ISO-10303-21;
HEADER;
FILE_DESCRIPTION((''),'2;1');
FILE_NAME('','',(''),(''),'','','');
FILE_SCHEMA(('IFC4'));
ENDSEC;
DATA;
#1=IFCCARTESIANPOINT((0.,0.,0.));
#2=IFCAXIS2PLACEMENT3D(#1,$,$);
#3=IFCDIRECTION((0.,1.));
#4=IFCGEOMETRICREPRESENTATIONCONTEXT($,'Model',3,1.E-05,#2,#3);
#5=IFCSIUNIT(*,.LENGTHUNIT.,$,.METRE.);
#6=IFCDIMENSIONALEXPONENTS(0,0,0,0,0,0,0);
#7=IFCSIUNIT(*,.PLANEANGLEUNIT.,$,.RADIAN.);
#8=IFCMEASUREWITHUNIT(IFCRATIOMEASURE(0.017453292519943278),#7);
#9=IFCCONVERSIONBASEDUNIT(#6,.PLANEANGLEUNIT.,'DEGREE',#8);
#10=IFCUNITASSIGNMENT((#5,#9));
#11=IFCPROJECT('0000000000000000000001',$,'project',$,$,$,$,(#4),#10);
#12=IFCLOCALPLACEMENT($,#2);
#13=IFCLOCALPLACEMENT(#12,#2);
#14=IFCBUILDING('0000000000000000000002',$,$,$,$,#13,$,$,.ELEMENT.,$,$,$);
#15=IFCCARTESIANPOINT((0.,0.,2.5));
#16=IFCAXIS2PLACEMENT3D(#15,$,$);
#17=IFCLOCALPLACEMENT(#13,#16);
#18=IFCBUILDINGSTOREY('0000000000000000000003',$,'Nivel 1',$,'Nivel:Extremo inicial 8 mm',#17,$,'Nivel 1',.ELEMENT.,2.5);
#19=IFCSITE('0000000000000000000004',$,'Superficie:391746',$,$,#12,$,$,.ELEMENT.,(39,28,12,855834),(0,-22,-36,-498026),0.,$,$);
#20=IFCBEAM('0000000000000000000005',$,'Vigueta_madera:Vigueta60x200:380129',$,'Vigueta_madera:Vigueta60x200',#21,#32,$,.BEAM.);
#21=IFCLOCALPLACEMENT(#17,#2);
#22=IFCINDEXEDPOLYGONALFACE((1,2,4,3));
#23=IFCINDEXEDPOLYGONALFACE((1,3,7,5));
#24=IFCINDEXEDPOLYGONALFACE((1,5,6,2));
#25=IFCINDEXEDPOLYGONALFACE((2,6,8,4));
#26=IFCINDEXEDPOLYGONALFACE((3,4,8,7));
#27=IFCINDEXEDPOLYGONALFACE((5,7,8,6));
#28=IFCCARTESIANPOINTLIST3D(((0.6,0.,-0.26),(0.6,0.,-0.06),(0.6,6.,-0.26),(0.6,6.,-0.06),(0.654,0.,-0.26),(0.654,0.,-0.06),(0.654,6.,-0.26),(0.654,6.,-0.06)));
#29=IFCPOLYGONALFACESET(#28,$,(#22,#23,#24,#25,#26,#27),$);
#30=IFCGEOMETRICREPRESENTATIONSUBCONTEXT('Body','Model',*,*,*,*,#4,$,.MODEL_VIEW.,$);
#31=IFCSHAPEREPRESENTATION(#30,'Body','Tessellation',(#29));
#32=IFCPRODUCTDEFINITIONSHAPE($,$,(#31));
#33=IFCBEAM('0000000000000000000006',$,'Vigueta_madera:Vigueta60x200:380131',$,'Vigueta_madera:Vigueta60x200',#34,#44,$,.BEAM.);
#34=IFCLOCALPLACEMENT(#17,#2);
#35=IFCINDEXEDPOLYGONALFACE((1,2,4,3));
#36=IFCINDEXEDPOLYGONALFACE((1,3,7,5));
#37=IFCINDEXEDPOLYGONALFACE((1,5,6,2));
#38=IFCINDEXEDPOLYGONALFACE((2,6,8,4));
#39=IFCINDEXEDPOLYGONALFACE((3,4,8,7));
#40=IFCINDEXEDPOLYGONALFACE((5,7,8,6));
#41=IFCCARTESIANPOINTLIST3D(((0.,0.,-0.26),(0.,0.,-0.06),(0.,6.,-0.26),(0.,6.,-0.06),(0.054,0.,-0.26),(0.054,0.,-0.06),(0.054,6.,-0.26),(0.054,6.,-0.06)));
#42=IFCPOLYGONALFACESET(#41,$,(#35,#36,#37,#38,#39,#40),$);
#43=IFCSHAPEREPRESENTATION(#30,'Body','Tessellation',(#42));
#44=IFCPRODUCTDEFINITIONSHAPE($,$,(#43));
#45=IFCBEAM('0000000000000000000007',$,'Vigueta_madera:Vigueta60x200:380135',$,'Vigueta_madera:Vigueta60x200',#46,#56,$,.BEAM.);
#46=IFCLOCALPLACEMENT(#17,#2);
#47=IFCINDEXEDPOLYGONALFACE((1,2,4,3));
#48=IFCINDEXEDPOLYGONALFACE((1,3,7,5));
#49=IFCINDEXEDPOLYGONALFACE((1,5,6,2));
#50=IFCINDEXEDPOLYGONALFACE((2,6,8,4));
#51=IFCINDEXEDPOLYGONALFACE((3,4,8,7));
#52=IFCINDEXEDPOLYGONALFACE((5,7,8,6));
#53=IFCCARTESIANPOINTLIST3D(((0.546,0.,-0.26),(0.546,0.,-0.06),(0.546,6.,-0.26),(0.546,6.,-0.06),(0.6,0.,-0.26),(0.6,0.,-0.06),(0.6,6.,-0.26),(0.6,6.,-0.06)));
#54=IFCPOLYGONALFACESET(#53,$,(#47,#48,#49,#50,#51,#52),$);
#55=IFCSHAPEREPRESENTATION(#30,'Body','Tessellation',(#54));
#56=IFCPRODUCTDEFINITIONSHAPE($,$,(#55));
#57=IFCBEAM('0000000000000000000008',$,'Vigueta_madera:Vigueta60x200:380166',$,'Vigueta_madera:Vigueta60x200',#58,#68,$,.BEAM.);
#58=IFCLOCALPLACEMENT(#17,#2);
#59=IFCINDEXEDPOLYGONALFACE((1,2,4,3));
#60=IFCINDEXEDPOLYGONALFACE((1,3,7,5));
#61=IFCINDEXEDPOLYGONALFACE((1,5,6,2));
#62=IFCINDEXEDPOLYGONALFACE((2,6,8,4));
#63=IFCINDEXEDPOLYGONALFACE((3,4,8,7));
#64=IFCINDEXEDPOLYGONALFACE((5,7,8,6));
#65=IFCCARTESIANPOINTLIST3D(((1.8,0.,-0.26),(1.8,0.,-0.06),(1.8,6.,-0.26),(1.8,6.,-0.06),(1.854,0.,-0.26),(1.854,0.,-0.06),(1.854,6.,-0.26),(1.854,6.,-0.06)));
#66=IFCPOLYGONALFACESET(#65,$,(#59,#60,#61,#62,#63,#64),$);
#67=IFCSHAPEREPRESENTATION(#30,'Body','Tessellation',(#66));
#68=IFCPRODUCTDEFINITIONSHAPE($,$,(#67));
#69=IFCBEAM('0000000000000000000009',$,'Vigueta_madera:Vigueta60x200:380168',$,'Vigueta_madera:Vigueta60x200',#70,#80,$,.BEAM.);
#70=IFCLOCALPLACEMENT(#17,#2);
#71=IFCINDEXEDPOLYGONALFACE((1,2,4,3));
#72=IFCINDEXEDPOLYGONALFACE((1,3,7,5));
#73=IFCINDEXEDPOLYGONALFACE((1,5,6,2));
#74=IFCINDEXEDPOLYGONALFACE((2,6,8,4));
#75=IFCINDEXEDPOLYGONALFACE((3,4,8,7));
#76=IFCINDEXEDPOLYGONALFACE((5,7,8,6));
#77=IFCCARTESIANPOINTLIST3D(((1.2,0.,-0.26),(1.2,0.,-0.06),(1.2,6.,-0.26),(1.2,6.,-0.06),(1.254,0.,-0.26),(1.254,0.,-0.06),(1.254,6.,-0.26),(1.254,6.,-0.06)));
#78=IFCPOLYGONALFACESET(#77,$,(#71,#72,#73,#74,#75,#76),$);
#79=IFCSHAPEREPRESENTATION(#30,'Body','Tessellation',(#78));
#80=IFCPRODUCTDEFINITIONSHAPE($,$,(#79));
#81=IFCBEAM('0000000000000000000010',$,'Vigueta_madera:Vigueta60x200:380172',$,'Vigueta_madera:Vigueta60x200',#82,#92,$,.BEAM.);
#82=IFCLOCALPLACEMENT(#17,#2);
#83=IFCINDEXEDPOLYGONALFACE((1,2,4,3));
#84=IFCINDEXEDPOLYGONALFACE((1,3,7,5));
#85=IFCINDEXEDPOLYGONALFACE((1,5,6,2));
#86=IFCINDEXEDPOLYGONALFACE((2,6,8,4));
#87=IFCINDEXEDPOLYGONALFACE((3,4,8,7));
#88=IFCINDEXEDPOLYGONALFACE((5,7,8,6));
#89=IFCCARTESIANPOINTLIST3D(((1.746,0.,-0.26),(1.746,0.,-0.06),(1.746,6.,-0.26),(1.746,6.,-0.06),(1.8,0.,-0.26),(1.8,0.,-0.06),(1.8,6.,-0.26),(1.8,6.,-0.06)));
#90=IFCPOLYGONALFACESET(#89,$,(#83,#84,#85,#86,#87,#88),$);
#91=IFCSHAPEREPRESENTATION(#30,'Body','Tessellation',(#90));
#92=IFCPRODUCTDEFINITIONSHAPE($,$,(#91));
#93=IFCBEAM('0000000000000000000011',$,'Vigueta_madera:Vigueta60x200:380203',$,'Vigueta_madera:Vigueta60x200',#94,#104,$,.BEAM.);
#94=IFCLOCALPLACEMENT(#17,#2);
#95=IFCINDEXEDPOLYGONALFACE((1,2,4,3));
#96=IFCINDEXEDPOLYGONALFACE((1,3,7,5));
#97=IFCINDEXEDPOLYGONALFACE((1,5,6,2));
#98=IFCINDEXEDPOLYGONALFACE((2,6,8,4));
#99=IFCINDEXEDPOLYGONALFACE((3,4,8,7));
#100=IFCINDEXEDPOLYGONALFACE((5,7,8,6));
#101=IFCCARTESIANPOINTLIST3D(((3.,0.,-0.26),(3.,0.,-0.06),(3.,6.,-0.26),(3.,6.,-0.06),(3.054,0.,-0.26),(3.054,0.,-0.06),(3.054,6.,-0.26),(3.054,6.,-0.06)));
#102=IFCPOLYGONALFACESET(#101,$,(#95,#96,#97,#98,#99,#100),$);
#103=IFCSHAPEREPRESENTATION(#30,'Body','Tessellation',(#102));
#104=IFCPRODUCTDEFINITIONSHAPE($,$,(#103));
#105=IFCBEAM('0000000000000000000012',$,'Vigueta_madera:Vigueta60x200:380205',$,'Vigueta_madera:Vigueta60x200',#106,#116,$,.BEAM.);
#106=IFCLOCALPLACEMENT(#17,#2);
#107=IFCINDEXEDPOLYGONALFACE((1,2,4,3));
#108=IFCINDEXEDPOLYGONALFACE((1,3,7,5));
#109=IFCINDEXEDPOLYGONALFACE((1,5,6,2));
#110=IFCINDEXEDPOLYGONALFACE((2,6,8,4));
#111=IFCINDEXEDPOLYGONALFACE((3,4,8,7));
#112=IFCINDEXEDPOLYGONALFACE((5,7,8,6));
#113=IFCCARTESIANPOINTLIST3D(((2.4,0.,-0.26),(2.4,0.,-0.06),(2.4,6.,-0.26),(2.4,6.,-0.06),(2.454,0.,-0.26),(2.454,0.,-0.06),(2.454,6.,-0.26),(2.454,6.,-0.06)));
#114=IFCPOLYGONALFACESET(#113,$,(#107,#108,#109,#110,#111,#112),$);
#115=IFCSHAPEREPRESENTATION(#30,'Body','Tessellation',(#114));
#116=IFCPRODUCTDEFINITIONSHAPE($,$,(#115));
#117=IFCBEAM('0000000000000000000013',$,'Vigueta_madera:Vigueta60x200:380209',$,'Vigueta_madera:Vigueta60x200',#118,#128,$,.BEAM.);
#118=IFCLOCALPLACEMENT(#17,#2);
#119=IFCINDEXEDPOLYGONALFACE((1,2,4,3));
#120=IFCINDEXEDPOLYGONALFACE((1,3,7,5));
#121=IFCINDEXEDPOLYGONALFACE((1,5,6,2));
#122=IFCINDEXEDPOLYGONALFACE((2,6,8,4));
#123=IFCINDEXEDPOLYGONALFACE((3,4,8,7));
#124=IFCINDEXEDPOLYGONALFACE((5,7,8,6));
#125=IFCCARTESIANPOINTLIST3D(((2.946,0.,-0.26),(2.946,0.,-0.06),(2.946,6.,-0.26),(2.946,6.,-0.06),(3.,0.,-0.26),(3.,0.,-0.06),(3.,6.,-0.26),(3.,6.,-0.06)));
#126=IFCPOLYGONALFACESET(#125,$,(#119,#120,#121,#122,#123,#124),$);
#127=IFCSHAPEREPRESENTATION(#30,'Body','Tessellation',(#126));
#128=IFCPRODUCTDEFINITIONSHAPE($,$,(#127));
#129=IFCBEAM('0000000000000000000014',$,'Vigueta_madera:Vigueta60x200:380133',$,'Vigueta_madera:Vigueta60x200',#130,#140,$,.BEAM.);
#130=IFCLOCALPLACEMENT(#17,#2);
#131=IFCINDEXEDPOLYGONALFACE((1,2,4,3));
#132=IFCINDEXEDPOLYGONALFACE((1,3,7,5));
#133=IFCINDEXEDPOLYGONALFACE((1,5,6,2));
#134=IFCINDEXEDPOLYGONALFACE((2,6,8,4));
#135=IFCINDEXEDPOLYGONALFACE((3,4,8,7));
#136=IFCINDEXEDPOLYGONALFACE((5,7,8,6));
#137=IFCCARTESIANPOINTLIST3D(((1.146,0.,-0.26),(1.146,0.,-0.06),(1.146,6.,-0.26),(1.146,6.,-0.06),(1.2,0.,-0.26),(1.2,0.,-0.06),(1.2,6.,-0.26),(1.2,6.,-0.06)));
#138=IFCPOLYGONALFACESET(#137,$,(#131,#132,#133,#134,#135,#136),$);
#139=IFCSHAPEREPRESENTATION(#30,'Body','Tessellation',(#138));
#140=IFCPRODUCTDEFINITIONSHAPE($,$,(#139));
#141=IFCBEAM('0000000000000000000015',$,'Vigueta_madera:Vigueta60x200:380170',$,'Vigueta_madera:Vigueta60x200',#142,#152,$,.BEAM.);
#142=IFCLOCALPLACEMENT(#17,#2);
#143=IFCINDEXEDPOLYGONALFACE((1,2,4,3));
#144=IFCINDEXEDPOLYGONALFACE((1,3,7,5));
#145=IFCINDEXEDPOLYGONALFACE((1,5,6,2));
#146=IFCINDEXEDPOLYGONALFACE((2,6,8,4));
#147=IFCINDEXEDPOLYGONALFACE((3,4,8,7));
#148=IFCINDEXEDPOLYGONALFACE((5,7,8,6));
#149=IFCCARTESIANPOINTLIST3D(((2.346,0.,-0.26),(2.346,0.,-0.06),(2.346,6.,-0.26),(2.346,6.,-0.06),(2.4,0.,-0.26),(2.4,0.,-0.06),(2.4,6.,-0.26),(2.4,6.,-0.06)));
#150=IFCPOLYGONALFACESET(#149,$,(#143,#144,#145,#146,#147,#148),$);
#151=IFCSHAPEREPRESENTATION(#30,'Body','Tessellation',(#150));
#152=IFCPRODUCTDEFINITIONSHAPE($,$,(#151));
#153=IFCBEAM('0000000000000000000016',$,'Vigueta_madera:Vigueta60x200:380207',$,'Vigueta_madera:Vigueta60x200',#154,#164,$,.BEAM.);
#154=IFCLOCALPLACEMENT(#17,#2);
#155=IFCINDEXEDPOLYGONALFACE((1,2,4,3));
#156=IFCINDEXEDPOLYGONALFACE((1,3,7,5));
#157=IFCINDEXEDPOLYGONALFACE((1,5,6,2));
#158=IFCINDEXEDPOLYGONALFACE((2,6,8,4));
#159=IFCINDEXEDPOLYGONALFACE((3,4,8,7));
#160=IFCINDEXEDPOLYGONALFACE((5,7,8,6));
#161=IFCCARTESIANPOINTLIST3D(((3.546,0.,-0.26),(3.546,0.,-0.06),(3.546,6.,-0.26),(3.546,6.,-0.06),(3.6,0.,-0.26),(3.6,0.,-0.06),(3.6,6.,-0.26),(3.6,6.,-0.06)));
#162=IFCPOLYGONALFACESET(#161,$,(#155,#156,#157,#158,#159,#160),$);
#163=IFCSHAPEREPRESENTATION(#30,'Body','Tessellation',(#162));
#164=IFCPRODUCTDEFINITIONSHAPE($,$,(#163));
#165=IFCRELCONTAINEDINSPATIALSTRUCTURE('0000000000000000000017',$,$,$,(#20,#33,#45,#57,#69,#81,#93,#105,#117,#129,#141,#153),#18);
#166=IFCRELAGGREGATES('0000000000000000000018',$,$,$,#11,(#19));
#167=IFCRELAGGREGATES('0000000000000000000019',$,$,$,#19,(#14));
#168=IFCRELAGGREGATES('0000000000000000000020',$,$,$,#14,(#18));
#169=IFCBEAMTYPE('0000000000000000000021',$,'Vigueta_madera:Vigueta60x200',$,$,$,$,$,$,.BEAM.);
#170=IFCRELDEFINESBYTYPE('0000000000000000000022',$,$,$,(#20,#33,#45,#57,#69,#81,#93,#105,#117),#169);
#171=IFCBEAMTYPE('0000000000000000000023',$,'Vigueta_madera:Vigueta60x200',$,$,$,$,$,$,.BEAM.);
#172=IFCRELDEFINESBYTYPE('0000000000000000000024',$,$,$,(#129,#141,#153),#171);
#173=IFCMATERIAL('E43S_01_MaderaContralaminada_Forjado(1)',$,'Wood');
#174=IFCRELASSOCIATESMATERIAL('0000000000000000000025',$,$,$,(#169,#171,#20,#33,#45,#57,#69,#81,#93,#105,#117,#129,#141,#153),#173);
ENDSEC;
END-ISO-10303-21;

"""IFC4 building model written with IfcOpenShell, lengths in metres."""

from ifc_helpers import new_model, entity, si_unit, converted_unit, direction, frame, origin, origin_2d_with_axis, place, context, subcontext, project, spatial, polyline, segment, composite_curve, rectangle, outline, extrude, source, transform, mapped, material, material_profile, profile_set, profile_usage, type_object, type_shapes, element, save


model = new_model("IFC4")

# Units and contexts
model_context = context("Model", 3, precision=1e-05, world=origin(), true_north=direction((0.0, 1.0)))
body_context = subcontext(model_context, "Body", "Model", "MODEL_VIEW")
ifc_project = project(units=[si_unit("LENGTHUNIT", "METRE"), converted_unit("PLANEANGLEUNIT", "DEGREE", entity("IfcRatioMeasure", 0.017453292519943278), si_unit("PLANEANGLEUNIT", "RADIAN"), dimensions=[0, 0, 0, 0, 0, 0, 0])], contexts=[model_context])

# Site, building, storey
site_placement = place(None, origin())
site = spatial("IfcSite", under=ifc_project, at=site_placement, Name="Superficie:391746", CompositionType="ELEMENT", RefLatitude=(39, 28, 12, 855834), RefLongitude=(0, -22, -36, -498026), RefElevation=0.0)
building_placement = place(site_placement, origin())
building = spatial("IfcBuilding", under=site, at=building_placement, CompositionType="ELEMENT")
storey_placement = place(building_placement, frame((0.0, 0.0, 2.5)))
storey = spatial("IfcBuildingStorey", under=building, at=storey_placement, Name="Nivel 1", ObjectType="Nivel:Extremo inicial 8 mm", LongName="Nivel 1", CompositionType="ELEMENT", Elevation=2.5)

# Beams
ifc_material_1 = material(Name="E43S_01_MaderaContralaminada_Forjado(1)", Category="Wood")
ifc_material_profile_1 = material_profile(ifc_material_1, outline(composite_curve([segment(polyline([(-0.027, -0.1, 0.0), (-0.027, 0.1, 0.0)]), True, "CONTINUOUS"), segment(polyline([(-0.027, 0.1, 0.0), (0.027, 0.1, 0.0)]), True, "CONTINUOUS"), segment(polyline([(0.027, 0.1, 0.0), (0.027, -0.1, 0.0)]), True, "CONTINUOUS"), segment(polyline([(0.027, -0.1, 0.0), (-0.027, -0.1, 0.0)]), True, "CONTINUOUS")], self_intersect=False), kind="CURVE"), Name="Vigueta60x200")
ifc_material_profile_2 = material_profile(ifc_material_1, outline(composite_curve([segment(polyline([(3.0, 0.027, 0.1), (3.0, 0.027, -0.1)]), True, "CONTINUOUS"), segment(polyline([(3.0, 0.027, -0.1), (-3.0, 0.027, -0.1)]), True, "CONTINUOUS"), segment(polyline([(-3.0, 0.027, -0.1), (-3.0, 0.027, 0.1)]), True, "CONTINUOUS"), segment(polyline([(-3.0, 0.027, 0.1), (3.0, 0.027, 0.1)]), True, "CONTINUOUS")], self_intersect=False), kind="CURVE"), Name="Vigueta60x200")
ifc_profile_set_1 = profile_set([ifc_material_profile_1, ifc_material_profile_2], Name="Vigueta60x200")
ifc_profile_usage_1 = profile_usage(ifc_profile_set_1, cardinal=8)
beam_type_1 = type_object("IfcBeamType", Name="Vigueta_madera:Vigueta60x200", PredefinedType="BEAM", material=ifc_profile_set_1)
shared_shape_1 = source(origin(), body_context, "Body", "SweptSolid", [
    extrude(rectangle(XDim=0.2, YDim=0.054, at=origin_2d_with_axis()), frame((-3.0, 0.0, 0.0), z_axis=(1.0, 0.0, 0.0), x_axis=(0.0, 0.0, -1.0)), (0.0, 0.0, 1.0), 6.0),
])
type_shapes(beam_type_1, [shared_shape_1])
beam_1_placement = place(storey_placement, frame((0.627, 3.0, -0.16), z_axis=(0.0, 0.0, 1.0), x_axis=(0.0, 1.0, 0.0)))
element("IfcBeam", 1, at=beam_1_placement, inside=storey, type_object=beam_type_1, material=ifc_profile_usage_1, Name="Vigueta_madera:Vigueta60x200:380129", ObjectType="Vigueta_madera:Vigueta60x200", PredefinedType="BEAM", context=body_context, shape_type="MappedRepresentation", body=[
    mapped(shared_shape_1, transform((0.0, 0.0, 0.0), scale=1.0)),
])
ifc_profile_usage_2 = profile_usage(ifc_profile_set_1, cardinal=8)
beam_2_placement = place(storey_placement, frame((0.027, 3.0, -0.16), z_axis=(0.0, 0.0, 1.0), x_axis=(0.0, 1.0, 0.0)))
element("IfcBeam", 2, at=beam_2_placement, inside=storey, type_object=beam_type_1, material=ifc_profile_usage_2, Name="Vigueta_madera:Vigueta60x200:380131", ObjectType="Vigueta_madera:Vigueta60x200", PredefinedType="BEAM", context=body_context, shape_type="MappedRepresentation", body=[
    mapped(shared_shape_1, transform((0.0, 0.0, 0.0), scale=1.0)),
])
ifc_profile_usage_3 = profile_usage(ifc_profile_set_1, cardinal=8)
beam_3_placement = place(storey_placement, frame((0.573, 3.0, -0.16), z_axis=(0.0, 0.0, 1.0), x_axis=(0.0, 1.0, 0.0)))
element("IfcBeam", 3, at=beam_3_placement, inside=storey, type_object=beam_type_1, material=ifc_profile_usage_3, Name="Vigueta_madera:Vigueta60x200:380135", ObjectType="Vigueta_madera:Vigueta60x200", PredefinedType="BEAM", context=body_context, shape_type="MappedRepresentation", body=[
    mapped(shared_shape_1, transform((0.0, 0.0, 0.0), scale=1.0)),
])
ifc_profile_usage_4 = profile_usage(ifc_profile_set_1, cardinal=8)
beam_4_placement = place(storey_placement, frame((1.827, 3.0, -0.16), z_axis=(0.0, 0.0, 1.0), x_axis=(0.0, 1.0, 0.0)))
element("IfcBeam", 4, at=beam_4_placement, inside=storey, type_object=beam_type_1, material=ifc_profile_usage_4, Name="Vigueta_madera:Vigueta60x200:380166", ObjectType="Vigueta_madera:Vigueta60x200", PredefinedType="BEAM", context=body_context, shape_type="MappedRepresentation", body=[
    mapped(shared_shape_1, transform((0.0, 0.0, 0.0), scale=1.0)),
])
ifc_profile_usage_5 = profile_usage(ifc_profile_set_1, cardinal=8)
beam_5_placement = place(storey_placement, frame((1.227, 3.0, -0.16), z_axis=(0.0, 0.0, 1.0), x_axis=(0.0, 1.0, 0.0)))
element("IfcBeam", 5, at=beam_5_placement, inside=storey, type_object=beam_type_1, material=ifc_profile_usage_5, Name="Vigueta_madera:Vigueta60x200:380168", ObjectType="Vigueta_madera:Vigueta60x200", PredefinedType="BEAM", context=body_context, shape_type="MappedRepresentation", body=[
    mapped(shared_shape_1, transform((0.0, 0.0, 0.0), scale=1.0)),
])
ifc_profile_usage_6 = profile_usage(ifc_profile_set_1, cardinal=8)
beam_6_placement = place(storey_placement, frame((1.773, 3.0, -0.16), z_axis=(0.0, 0.0, 1.0), x_axis=(0.0, 1.0, 0.0)))
element("IfcBeam", 6, at=beam_6_placement, inside=storey, type_object=beam_type_1, material=ifc_profile_usage_6, Name="Vigueta_madera:Vigueta60x200:380172", ObjectType="Vigueta_madera:Vigueta60x200", PredefinedType="BEAM", context=body_context, shape_type="MappedRepresentation", body=[
    mapped(shared_shape_1, transform((0.0, 0.0, 0.0), scale=1.0)),
])
ifc_profile_usage_7 = profile_usage(ifc_profile_set_1, cardinal=8)
beam_7_placement = place(storey_placement, frame((3.027, 3.0, -0.16), z_axis=(0.0, 0.0, 1.0), x_axis=(0.0, 1.0, 0.0)))
element("IfcBeam", 7, at=beam_7_placement, inside=storey, type_object=beam_type_1, material=ifc_profile_usage_7, Name="Vigueta_madera:Vigueta60x200:380203", ObjectType="Vigueta_madera:Vigueta60x200", PredefinedType="BEAM", context=body_context, shape_type="MappedRepresentation", body=[
    mapped(shared_shape_1, transform((0.0, 0.0, 0.0), scale=1.0)),
])
ifc_profile_usage_8 = profile_usage(ifc_profile_set_1, cardinal=8)
beam_8_placement = place(storey_placement, frame((2.427, 3.0, -0.16), z_axis=(0.0, 0.0, 1.0), x_axis=(0.0, 1.0, 0.0)))
element("IfcBeam", 8, at=beam_8_placement, inside=storey, type_object=beam_type_1, material=ifc_profile_usage_8, Name="Vigueta_madera:Vigueta60x200:380205", ObjectType="Vigueta_madera:Vigueta60x200", PredefinedType="BEAM", context=body_context, shape_type="MappedRepresentation", body=[
    mapped(shared_shape_1, transform((0.0, 0.0, 0.0), scale=1.0)),
])
ifc_profile_usage_9 = profile_usage(ifc_profile_set_1, cardinal=8)
beam_9_placement = place(storey_placement, frame((2.973, 3.0, -0.16), z_axis=(0.0, 0.0, 1.0), x_axis=(0.0, 1.0, 0.0)))
element("IfcBeam", 9, at=beam_9_placement, inside=storey, type_object=beam_type_1, material=ifc_profile_usage_9, Name="Vigueta_madera:Vigueta60x200:380209", ObjectType="Vigueta_madera:Vigueta60x200", PredefinedType="BEAM", context=body_context, shape_type="MappedRepresentation", body=[
    mapped(shared_shape_1, transform((0.0, 0.0, 0.0), scale=1.0)),
])
ifc_profile_usage_10 = profile_usage(ifc_profile_set_1, cardinal=8)
beam_type_2 = type_object("IfcBeamType", Name="Vigueta_madera:Vigueta60x200", PredefinedType="BEAM", material=ifc_profile_set_1)
shared_shape_2 = source(origin(), body_context, "Body", "SweptSolid", [
    extrude(rectangle(XDim=0.2, YDim=0.054, at=origin_2d_with_axis()), frame((-3.06, 0.0, 0.0), z_axis=(1.0, 0.0, 0.0), x_axis=(0.0, 0.0, -1.0)), (0.0, 0.0, 1.0), 6.0),
])
type_shapes(beam_type_2, [shared_shape_2])
beam_10_placement = place(storey_placement, frame((1.173, 3.06, -0.16), z_axis=(0.0, 0.0, 1.0), x_axis=(0.0, 1.0, 0.0)))
element("IfcBeam", 10, at=beam_10_placement, inside=storey, type_object=beam_type_2, material=ifc_profile_usage_10, Name="Vigueta_madera:Vigueta60x200:380133", ObjectType="Vigueta_madera:Vigueta60x200", PredefinedType="BEAM", context=body_context, shape_type="MappedRepresentation", body=[
    mapped(shared_shape_2, transform((0.0, 0.0, 0.0), scale=1.0)),
])
ifc_profile_usage_11 = profile_usage(ifc_profile_set_1, cardinal=8)
beam_11_placement = place(storey_placement, frame((2.373, 3.06, -0.16), z_axis=(0.0, 0.0, 1.0), x_axis=(0.0, 1.0, 0.0)))
element("IfcBeam", 11, at=beam_11_placement, inside=storey, type_object=beam_type_2, material=ifc_profile_usage_11, Name="Vigueta_madera:Vigueta60x200:380170", ObjectType="Vigueta_madera:Vigueta60x200", PredefinedType="BEAM", context=body_context, shape_type="MappedRepresentation", body=[
    mapped(shared_shape_2, transform((0.0, 0.0, 0.0), scale=1.0)),
])
ifc_profile_usage_12 = profile_usage(ifc_profile_set_1, cardinal=8)
beam_12_placement = place(storey_placement, frame((3.573, 3.06, -0.16), z_axis=(0.0, 0.0, 1.0), x_axis=(0.0, 1.0, 0.0)))
element("IfcBeam", 12, at=beam_12_placement, inside=storey, type_object=beam_type_2, material=ifc_profile_usage_12, Name="Vigueta_madera:Vigueta60x200:380207", ObjectType="Vigueta_madera:Vigueta60x200", PredefinedType="BEAM", context=body_context, shape_type="MappedRepresentation", body=[
    mapped(shared_shape_2, transform((0.0, 0.0, 0.0), scale=1.0)),
])

save(model, "model.ifc")
